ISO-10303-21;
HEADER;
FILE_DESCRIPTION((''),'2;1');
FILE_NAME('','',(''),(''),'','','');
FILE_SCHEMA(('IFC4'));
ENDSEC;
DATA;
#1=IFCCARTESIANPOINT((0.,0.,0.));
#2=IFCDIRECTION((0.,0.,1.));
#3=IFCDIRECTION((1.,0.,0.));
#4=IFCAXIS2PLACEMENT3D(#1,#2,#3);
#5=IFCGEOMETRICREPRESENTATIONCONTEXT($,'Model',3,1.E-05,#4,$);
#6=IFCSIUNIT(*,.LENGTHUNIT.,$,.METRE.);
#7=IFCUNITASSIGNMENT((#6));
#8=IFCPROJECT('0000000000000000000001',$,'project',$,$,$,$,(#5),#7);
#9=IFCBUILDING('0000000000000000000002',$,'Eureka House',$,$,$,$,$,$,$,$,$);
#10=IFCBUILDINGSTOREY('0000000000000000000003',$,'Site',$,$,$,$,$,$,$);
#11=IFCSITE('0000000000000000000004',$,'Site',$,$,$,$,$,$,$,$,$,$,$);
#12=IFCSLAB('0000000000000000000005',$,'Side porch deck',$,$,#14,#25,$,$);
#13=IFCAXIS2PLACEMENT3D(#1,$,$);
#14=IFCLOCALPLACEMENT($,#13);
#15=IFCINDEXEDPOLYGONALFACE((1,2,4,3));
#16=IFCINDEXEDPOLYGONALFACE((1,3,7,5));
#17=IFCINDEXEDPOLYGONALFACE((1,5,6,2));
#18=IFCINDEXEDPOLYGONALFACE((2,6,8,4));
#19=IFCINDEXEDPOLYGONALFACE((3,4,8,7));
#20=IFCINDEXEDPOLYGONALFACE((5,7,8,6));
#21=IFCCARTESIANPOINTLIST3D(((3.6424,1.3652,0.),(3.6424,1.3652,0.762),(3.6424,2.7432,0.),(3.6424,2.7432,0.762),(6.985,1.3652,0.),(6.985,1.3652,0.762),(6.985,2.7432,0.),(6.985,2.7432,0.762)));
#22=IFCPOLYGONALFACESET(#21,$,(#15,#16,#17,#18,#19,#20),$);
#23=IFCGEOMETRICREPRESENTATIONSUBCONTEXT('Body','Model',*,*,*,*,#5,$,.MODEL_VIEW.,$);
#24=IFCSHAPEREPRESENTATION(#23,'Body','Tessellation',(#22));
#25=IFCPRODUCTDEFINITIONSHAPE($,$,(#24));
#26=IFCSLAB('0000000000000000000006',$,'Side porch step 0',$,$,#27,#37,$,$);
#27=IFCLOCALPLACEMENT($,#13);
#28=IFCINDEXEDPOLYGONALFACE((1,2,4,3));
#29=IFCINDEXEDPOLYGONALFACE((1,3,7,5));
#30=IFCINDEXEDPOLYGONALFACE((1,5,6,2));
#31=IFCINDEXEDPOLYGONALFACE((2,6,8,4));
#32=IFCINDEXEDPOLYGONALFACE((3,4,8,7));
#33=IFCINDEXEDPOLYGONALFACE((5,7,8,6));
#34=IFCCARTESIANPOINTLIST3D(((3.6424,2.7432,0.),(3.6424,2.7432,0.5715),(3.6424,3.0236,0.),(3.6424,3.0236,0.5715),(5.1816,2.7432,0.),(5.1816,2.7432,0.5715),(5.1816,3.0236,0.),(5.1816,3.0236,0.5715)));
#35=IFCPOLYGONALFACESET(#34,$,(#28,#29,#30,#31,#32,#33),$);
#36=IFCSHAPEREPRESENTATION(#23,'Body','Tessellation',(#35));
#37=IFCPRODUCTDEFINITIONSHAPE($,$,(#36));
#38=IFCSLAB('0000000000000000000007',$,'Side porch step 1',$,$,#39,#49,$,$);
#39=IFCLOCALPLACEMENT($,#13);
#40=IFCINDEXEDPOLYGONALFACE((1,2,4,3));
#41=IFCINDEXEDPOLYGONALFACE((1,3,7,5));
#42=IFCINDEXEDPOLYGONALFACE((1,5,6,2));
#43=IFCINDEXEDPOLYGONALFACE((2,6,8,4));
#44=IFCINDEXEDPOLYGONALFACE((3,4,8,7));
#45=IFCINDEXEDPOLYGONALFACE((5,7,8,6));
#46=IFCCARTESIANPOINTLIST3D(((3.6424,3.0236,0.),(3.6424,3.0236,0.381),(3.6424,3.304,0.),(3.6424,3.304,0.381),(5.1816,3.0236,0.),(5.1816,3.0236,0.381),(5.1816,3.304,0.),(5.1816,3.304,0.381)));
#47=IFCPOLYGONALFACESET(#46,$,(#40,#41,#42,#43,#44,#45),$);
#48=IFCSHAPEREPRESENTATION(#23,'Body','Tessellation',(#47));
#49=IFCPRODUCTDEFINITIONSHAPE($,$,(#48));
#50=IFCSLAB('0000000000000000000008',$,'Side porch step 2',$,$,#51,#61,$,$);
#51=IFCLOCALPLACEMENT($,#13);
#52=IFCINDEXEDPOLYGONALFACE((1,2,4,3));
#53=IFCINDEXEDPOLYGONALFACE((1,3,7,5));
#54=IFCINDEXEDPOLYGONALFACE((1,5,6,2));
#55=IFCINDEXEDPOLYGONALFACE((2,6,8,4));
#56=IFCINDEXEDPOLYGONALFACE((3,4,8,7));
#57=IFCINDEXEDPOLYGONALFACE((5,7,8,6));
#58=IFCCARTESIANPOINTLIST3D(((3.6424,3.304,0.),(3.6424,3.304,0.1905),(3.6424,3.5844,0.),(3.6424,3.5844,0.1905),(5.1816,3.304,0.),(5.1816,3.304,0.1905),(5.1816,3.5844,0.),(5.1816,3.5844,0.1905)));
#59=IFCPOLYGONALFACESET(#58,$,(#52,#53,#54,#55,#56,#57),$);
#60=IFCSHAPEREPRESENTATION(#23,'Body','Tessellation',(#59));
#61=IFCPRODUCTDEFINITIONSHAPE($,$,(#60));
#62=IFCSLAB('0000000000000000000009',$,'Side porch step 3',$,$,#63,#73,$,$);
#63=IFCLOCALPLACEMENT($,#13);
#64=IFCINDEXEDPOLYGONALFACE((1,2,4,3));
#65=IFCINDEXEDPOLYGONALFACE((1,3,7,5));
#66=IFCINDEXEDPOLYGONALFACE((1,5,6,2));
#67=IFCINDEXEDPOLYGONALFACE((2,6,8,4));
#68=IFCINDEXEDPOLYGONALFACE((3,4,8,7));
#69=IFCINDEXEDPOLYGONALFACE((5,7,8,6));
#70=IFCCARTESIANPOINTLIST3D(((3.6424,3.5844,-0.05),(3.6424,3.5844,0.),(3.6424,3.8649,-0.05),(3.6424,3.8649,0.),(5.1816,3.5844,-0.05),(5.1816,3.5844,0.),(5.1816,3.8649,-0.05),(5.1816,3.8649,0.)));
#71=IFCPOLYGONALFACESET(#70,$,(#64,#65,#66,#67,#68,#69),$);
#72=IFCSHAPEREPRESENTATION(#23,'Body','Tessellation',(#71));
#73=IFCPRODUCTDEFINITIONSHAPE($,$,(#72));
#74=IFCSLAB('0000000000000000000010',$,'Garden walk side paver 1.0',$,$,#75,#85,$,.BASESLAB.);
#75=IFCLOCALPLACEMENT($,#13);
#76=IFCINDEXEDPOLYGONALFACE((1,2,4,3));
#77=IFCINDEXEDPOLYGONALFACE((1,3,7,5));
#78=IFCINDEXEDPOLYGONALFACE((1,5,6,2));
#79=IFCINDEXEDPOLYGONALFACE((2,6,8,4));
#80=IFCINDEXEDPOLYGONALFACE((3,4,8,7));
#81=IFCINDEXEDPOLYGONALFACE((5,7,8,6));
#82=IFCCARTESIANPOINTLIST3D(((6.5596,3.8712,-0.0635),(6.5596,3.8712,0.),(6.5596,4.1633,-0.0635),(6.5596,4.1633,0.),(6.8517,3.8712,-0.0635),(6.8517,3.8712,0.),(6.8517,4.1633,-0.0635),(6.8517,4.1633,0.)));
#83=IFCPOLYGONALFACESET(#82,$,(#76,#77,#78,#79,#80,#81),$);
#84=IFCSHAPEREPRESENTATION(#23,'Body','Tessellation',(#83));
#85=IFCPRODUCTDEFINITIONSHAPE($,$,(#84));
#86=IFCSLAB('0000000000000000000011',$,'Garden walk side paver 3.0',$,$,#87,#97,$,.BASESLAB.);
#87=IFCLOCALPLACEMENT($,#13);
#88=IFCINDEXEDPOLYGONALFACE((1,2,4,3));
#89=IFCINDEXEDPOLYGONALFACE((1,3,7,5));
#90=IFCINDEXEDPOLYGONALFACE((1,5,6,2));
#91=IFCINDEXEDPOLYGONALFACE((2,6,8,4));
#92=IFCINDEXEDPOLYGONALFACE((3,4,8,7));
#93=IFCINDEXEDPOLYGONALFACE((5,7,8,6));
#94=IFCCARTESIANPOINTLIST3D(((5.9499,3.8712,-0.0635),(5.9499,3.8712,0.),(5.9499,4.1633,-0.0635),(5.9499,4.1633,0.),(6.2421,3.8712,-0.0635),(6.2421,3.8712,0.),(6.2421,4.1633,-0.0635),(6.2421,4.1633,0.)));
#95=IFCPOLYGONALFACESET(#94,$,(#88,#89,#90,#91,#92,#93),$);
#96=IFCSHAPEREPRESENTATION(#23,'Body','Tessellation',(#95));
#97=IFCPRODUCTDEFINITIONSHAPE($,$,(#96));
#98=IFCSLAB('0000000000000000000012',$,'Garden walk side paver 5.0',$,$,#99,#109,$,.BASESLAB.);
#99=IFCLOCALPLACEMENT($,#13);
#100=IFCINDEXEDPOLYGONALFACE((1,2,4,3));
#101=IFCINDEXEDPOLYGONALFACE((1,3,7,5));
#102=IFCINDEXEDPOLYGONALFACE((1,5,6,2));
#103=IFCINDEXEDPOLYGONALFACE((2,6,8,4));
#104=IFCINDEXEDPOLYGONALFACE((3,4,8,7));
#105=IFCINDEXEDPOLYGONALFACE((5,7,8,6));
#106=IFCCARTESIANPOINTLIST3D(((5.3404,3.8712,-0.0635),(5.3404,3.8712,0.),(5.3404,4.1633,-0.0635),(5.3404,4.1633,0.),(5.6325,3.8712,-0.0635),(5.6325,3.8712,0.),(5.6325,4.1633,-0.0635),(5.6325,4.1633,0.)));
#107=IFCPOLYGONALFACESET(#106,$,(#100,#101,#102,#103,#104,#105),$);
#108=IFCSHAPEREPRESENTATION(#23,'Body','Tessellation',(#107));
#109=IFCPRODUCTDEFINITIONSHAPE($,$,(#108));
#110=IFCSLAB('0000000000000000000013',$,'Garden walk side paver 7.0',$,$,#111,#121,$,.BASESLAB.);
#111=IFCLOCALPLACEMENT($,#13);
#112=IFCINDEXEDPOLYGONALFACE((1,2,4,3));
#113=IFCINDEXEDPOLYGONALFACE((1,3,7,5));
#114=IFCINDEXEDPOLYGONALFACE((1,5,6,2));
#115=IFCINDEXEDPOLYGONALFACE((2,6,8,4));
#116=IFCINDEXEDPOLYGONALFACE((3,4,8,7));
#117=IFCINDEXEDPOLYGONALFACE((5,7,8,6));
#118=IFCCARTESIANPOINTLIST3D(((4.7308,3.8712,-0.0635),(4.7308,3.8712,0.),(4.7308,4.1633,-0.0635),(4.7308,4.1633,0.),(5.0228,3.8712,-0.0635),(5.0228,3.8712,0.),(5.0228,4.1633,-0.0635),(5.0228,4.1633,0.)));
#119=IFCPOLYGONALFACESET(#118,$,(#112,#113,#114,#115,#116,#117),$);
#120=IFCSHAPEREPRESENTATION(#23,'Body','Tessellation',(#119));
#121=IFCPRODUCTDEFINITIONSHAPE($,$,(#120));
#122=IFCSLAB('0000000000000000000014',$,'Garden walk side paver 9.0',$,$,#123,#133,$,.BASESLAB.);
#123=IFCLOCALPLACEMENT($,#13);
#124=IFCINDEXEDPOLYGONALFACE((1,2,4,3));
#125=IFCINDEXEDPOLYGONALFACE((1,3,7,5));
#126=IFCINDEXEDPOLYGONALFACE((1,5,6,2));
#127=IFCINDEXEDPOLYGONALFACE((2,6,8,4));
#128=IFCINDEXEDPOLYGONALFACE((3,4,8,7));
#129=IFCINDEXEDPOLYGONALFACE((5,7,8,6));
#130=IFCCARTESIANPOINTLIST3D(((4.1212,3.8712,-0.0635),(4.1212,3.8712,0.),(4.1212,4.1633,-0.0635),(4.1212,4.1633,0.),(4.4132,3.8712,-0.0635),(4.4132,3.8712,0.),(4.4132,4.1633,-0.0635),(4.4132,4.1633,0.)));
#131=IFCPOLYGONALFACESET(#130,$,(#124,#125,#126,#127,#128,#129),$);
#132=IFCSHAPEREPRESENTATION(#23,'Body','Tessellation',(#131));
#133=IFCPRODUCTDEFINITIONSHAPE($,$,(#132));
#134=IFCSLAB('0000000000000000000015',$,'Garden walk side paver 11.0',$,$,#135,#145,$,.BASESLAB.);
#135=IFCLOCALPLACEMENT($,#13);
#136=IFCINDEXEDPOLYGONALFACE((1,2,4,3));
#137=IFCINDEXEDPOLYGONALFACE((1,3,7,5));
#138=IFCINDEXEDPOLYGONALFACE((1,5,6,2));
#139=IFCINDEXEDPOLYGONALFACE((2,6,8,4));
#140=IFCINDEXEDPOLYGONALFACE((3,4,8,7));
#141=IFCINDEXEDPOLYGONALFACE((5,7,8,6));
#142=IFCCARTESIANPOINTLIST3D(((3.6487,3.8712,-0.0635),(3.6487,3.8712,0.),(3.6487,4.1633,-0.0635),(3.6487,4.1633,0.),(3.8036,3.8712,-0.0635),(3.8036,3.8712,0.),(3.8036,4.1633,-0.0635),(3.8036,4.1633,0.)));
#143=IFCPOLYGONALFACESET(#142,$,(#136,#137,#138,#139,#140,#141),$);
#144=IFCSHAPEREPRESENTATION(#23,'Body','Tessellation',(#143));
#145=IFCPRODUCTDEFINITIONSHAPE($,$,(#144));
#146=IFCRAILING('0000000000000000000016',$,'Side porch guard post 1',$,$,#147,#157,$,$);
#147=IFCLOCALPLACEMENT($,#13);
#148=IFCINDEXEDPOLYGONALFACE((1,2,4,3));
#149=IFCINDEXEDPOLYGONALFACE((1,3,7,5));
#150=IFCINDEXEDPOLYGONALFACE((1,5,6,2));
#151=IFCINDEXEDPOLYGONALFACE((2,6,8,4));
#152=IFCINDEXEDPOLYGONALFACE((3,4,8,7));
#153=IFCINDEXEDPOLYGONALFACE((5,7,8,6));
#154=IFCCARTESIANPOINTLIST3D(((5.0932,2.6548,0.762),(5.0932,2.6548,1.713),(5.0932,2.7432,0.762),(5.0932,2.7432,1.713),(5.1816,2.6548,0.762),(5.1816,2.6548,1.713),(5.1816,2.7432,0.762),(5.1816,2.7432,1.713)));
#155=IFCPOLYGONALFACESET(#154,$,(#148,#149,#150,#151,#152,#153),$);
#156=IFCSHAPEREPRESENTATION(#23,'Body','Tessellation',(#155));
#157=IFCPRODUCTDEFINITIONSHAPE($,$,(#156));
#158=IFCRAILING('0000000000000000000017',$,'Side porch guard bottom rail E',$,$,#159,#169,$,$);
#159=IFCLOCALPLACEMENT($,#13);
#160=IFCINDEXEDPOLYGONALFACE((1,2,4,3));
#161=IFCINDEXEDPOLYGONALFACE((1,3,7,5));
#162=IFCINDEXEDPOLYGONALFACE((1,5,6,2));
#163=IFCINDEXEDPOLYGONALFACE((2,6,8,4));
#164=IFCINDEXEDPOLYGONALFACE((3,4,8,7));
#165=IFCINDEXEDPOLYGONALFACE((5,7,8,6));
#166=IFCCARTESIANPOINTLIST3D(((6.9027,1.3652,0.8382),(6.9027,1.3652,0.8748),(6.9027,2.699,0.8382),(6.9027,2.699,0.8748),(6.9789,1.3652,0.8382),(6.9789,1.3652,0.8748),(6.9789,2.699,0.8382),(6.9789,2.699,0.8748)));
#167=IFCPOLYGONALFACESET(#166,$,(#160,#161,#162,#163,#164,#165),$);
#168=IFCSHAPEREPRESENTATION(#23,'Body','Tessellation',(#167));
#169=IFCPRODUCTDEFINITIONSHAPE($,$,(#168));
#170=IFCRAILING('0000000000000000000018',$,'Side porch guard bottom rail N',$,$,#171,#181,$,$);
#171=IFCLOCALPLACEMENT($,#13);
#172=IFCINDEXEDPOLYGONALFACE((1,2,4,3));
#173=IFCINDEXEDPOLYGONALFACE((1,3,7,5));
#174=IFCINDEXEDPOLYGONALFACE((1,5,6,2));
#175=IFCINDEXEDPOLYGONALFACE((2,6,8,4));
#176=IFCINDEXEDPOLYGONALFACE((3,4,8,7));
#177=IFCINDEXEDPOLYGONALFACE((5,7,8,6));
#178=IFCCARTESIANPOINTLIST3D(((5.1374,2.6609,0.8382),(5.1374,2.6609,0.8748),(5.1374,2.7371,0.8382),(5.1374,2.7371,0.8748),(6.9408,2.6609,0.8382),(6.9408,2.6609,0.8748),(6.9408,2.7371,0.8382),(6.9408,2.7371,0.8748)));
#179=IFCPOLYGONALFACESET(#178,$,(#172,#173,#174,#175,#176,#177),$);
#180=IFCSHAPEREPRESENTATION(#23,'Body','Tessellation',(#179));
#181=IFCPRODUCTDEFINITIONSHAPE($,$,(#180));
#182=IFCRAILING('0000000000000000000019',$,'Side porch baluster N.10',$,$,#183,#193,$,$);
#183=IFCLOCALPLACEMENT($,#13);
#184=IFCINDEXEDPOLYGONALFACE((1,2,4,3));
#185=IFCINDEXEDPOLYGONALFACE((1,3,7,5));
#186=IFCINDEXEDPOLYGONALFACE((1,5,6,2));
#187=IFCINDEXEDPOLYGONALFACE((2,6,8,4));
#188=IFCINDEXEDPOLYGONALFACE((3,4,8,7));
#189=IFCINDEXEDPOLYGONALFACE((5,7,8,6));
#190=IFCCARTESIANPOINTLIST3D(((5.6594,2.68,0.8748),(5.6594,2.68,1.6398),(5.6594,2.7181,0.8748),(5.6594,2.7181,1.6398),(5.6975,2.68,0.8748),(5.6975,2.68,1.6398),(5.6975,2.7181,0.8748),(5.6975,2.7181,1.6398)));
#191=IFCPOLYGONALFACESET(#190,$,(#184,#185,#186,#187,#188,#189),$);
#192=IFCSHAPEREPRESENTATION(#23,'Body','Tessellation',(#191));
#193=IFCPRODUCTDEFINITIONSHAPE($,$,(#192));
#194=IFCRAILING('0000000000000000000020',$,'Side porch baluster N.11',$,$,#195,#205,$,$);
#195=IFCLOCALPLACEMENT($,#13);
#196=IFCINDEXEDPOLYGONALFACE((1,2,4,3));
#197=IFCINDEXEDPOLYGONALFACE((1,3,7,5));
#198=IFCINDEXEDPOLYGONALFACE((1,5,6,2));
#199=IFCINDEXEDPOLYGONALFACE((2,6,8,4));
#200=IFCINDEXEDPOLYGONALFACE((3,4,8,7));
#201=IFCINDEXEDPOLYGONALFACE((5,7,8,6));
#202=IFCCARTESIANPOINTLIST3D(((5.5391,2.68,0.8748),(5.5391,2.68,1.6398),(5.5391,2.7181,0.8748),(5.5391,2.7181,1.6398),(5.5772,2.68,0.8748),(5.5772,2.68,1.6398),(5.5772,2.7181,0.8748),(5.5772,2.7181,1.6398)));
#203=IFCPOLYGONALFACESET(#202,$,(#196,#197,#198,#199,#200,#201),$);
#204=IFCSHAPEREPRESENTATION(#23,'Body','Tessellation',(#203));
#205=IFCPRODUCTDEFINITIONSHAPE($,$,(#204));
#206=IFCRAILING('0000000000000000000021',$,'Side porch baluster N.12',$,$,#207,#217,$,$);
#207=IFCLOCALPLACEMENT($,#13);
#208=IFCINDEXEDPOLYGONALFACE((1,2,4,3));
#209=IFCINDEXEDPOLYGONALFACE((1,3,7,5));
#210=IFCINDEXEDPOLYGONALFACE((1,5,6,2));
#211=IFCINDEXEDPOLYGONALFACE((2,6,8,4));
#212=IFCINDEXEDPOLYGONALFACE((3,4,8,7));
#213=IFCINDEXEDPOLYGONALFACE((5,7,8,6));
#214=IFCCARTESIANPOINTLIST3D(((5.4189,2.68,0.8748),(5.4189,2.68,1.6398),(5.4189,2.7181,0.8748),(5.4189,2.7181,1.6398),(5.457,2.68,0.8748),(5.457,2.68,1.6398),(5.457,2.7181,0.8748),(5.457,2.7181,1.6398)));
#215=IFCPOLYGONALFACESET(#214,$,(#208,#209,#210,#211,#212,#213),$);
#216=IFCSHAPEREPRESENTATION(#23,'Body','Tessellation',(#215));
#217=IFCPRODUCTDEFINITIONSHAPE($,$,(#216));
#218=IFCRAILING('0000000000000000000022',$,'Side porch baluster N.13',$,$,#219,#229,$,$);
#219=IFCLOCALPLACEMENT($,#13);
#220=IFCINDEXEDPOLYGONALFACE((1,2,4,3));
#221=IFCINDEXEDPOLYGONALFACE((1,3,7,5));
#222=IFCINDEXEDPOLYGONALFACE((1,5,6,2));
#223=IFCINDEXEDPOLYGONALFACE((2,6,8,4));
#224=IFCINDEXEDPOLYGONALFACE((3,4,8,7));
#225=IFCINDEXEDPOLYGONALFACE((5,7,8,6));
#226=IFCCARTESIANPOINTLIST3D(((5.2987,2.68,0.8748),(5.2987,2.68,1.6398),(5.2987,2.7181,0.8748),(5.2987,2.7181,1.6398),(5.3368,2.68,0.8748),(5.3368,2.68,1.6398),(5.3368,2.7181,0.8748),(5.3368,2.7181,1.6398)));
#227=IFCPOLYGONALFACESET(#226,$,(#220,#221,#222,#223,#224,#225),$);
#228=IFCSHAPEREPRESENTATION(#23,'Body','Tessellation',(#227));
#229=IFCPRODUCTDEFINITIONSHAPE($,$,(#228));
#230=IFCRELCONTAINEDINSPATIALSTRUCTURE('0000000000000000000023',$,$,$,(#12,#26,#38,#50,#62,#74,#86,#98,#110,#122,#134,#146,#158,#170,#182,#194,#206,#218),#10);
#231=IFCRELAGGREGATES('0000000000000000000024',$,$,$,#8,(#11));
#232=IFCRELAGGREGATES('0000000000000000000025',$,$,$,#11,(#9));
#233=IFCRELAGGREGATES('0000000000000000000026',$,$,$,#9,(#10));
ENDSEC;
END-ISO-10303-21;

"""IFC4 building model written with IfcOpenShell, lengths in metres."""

from ifc_helpers import new_model, si_unit, frame, origin, origin_with_axes, origin_2d, place, context, subcontext, project, spatial, rectangle, extrude, element, save


model = new_model("IFC4")

# Units and contexts
model_context = context("Model", 3, precision=1e-05, world=origin_with_axes())
body_context = subcontext(model_context, "Body", "Model", "MODEL_VIEW")
ifc_project = project(units=[si_unit("LENGTHUNIT", "METRE")], contexts=[model_context])

# Site, building, storey
site = spatial("IfcSite", under=ifc_project, Name="Site")
building = spatial("IfcBuilding", under=site, Name="Eureka House")
storey = spatial("IfcBuildingStorey", under=building, Name="Site")

# Slabs
slab_1_placement = place(None, frame((5.3137, 2.0542, 0.0), z_axis=(0.0, 0.0, 1.0), x_axis=(1.0, 0.0, 0.0)))
element("IfcSlab", 1, at=slab_1_placement, inside=storey, Name="Side porch deck", context=body_context, shape_type="SweptSolid", body=[
    extrude(rectangle(XDim=3.3427, YDim=1.378, at=origin_2d()), origin(), (0.0, 0.0, 1.0), 0.762),
])
slab_2_placement = place(None, frame((4.412, 2.8834, 0.0), z_axis=(0.0, 0.0, 1.0), x_axis=(1.0, 0.0, 0.0)))
element("IfcSlab", 2, at=slab_2_placement, inside=storey, Name="Side porch step 0", context=body_context, shape_type="SweptSolid", body=[
    extrude(rectangle(XDim=1.5392, YDim=0.2804, at=origin_2d()), origin(), (0.0, 0.0, 1.0), 0.5715),
])
slab_3_placement = place(None, frame((4.412, 3.1638, 0.0), z_axis=(0.0, 0.0, 1.0), x_axis=(1.0, 0.0, 0.0)))
element("IfcSlab", 3, at=slab_3_placement, inside=storey, Name="Side porch step 1", context=body_context, shape_type="SweptSolid", body=[
    extrude(rectangle(XDim=1.5392, YDim=0.2804, at=origin_2d()), origin(), (0.0, 0.0, 1.0), 0.381),
])
slab_4_placement = place(None, frame((4.412, 3.4442, 0.0), z_axis=(0.0, 0.0, 1.0), x_axis=(1.0, 0.0, 0.0)))
element("IfcSlab", 4, at=slab_4_placement, inside=storey, Name="Side porch step 2", context=body_context, shape_type="SweptSolid", body=[
    extrude(rectangle(XDim=1.5392, YDim=0.2804, at=origin_2d()), origin(), (0.0, 0.0, 1.0), 0.1905),
])
slab_5_placement = place(None, frame((4.412, 3.7247, -0.05), z_axis=(0.0, 0.0, 1.0), x_axis=(1.0, 0.0, 0.0)))
element("IfcSlab", 5, at=slab_5_placement, inside=storey, Name="Side porch step 3", context=body_context, shape_type="SweptSolid", body=[
    extrude(rectangle(XDim=1.5392, YDim=0.2804, at=origin_2d()), origin(), (0.0, 0.0, 1.0), 0.05),
])
for number, where, z_axis, x_axis, name in (
    (6, (6.7056, 4.0173, -0.0635), (0.0, 0.0, 1.0), (1.0, 0.0, 0.0), "Garden walk side paver 1.0"),
    (7, (6.096, 4.0173, -0.0635), (0.0, 0.0, 1.0), (1.0, 0.0, 0.0), "Garden walk side paver 3.0"),
    (8, (5.4864, 4.0173, -0.0635), (0.0, 0.0, 1.0), (1.0, 0.0, 0.0), "Garden walk side paver 5.0"),
):
    element("IfcSlab", number, at=place(None, frame(where, z_axis=z_axis, x_axis=x_axis)), inside=storey, Name=name, PredefinedType="BASESLAB", context=body_context, shape_type="SweptSolid", body=[
        extrude(rectangle(XDim=0.2921, YDim=0.2921, at=origin_2d()), origin(), (0.0, 0.0, 1.0), 0.0635),
    ])
slab_6_placement = place(None, frame((4.8768, 4.0173, -0.0635), z_axis=(0.0, 0.0, 1.0), x_axis=(1.0, 0.0, 0.0)))
element("IfcSlab", 9, at=slab_6_placement, inside=storey, Name="Garden walk side paver 7.0", PredefinedType="BASESLAB", context=body_context, shape_type="SweptSolid", body=[
    extrude(rectangle(XDim=0.2921, YDim=0.2921, at=origin_2d()), origin(), (0.0, 0.0, 1.0), 0.0635),
])
slab_7_placement = place(None, frame((4.2672, 4.0173, -0.0635), z_axis=(0.0, 0.0, 1.0), x_axis=(1.0, 0.0, 0.0)))
element("IfcSlab", 10, at=slab_7_placement, inside=storey, Name="Garden walk side paver 9.0", PredefinedType="BASESLAB", context=body_context, shape_type="SweptSolid", body=[
    extrude(rectangle(XDim=0.2921, YDim=0.2921, at=origin_2d()), origin(), (0.0, 0.0, 1.0), 0.0635),
])
slab_8_placement = place(None, frame((3.7262, 4.0173, -0.0635), z_axis=(0.0, 0.0, 1.0), x_axis=(1.0, 0.0, 0.0)))
element("IfcSlab", 11, at=slab_8_placement, inside=storey, Name="Garden walk side paver 11.0", PredefinedType="BASESLAB", context=body_context, shape_type="SweptSolid", body=[
    extrude(rectangle(XDim=0.1549, YDim=0.2921, at=origin_2d()), origin(), (0.0, 0.0, 1.0), 0.0635),
])

# Railings
railing_1_placement = place(None, frame((5.1374, 2.699, 0.762), z_axis=(0.0, 0.0, 1.0), x_axis=(1.0, 0.0, 0.0)))
element("IfcRailing", 12, at=railing_1_placement, inside=storey, Name="Side porch guard post 1", context=body_context, shape_type="SweptSolid", body=[
    extrude(rectangle(XDim=0.0884, YDim=0.0884, at=origin_2d()), origin(), (0.0, 0.0, 1.0), 0.951),
])
railing_2_placement = place(None, frame((6.9408, 2.0321, 0.8382), z_axis=(0.0, 0.0, 1.0), x_axis=(1.0, 0.0, 0.0)))
element("IfcRailing", 13, at=railing_2_placement, inside=storey, Name="Side porch guard bottom rail E", context=body_context, shape_type="SweptSolid", body=[
    extrude(rectangle(XDim=0.0762, YDim=1.3338, at=origin_2d()), origin(), (0.0, 0.0, 1.0), 0.0366),
])
railing_3_placement = place(None, frame((6.0391, 2.699, 0.8382), z_axis=(0.0, 0.0, 1.0), x_axis=(1.0, 0.0, 0.0)))
element("IfcRailing", 14, at=railing_3_placement, inside=storey, Name="Side porch guard bottom rail N", context=body_context, shape_type="SweptSolid", body=[
    extrude(rectangle(XDim=1.8034, YDim=0.0762, at=origin_2d()), origin(), (0.0, 0.0, 1.0), 0.0366),
])
for number, where, z_axis, x_axis, name in (
    (15, (5.6784, 2.699, 0.8748), (0.0, 0.0, 1.0), (1.0, 0.0, 0.0), "Side porch baluster N.10"),
    (16, (5.5582, 2.699, 0.8748), (0.0, 0.0, 1.0), (1.0, 0.0, 0.0), "Side porch baluster N.11"),
    (17, (5.438, 2.699, 0.8748), (0.0, 0.0, 1.0), (1.0, 0.0, 0.0), "Side porch baluster N.12"),
    (18, (5.3177, 2.699, 0.8748), (0.0, 0.0, 1.0), (1.0, 0.0, 0.0), "Side porch baluster N.13"),
):
    element("IfcRailing", number, at=place(None, frame(where, z_axis=z_axis, x_axis=x_axis)), inside=storey, Name=name, context=body_context, shape_type="SweptSolid", body=[
        extrude(rectangle(XDim=0.0381, YDim=0.0381, at=origin_2d()), origin(), (0.0, 0.0, 1.0), 0.765),
    ])

save(model, "model.ifc")
